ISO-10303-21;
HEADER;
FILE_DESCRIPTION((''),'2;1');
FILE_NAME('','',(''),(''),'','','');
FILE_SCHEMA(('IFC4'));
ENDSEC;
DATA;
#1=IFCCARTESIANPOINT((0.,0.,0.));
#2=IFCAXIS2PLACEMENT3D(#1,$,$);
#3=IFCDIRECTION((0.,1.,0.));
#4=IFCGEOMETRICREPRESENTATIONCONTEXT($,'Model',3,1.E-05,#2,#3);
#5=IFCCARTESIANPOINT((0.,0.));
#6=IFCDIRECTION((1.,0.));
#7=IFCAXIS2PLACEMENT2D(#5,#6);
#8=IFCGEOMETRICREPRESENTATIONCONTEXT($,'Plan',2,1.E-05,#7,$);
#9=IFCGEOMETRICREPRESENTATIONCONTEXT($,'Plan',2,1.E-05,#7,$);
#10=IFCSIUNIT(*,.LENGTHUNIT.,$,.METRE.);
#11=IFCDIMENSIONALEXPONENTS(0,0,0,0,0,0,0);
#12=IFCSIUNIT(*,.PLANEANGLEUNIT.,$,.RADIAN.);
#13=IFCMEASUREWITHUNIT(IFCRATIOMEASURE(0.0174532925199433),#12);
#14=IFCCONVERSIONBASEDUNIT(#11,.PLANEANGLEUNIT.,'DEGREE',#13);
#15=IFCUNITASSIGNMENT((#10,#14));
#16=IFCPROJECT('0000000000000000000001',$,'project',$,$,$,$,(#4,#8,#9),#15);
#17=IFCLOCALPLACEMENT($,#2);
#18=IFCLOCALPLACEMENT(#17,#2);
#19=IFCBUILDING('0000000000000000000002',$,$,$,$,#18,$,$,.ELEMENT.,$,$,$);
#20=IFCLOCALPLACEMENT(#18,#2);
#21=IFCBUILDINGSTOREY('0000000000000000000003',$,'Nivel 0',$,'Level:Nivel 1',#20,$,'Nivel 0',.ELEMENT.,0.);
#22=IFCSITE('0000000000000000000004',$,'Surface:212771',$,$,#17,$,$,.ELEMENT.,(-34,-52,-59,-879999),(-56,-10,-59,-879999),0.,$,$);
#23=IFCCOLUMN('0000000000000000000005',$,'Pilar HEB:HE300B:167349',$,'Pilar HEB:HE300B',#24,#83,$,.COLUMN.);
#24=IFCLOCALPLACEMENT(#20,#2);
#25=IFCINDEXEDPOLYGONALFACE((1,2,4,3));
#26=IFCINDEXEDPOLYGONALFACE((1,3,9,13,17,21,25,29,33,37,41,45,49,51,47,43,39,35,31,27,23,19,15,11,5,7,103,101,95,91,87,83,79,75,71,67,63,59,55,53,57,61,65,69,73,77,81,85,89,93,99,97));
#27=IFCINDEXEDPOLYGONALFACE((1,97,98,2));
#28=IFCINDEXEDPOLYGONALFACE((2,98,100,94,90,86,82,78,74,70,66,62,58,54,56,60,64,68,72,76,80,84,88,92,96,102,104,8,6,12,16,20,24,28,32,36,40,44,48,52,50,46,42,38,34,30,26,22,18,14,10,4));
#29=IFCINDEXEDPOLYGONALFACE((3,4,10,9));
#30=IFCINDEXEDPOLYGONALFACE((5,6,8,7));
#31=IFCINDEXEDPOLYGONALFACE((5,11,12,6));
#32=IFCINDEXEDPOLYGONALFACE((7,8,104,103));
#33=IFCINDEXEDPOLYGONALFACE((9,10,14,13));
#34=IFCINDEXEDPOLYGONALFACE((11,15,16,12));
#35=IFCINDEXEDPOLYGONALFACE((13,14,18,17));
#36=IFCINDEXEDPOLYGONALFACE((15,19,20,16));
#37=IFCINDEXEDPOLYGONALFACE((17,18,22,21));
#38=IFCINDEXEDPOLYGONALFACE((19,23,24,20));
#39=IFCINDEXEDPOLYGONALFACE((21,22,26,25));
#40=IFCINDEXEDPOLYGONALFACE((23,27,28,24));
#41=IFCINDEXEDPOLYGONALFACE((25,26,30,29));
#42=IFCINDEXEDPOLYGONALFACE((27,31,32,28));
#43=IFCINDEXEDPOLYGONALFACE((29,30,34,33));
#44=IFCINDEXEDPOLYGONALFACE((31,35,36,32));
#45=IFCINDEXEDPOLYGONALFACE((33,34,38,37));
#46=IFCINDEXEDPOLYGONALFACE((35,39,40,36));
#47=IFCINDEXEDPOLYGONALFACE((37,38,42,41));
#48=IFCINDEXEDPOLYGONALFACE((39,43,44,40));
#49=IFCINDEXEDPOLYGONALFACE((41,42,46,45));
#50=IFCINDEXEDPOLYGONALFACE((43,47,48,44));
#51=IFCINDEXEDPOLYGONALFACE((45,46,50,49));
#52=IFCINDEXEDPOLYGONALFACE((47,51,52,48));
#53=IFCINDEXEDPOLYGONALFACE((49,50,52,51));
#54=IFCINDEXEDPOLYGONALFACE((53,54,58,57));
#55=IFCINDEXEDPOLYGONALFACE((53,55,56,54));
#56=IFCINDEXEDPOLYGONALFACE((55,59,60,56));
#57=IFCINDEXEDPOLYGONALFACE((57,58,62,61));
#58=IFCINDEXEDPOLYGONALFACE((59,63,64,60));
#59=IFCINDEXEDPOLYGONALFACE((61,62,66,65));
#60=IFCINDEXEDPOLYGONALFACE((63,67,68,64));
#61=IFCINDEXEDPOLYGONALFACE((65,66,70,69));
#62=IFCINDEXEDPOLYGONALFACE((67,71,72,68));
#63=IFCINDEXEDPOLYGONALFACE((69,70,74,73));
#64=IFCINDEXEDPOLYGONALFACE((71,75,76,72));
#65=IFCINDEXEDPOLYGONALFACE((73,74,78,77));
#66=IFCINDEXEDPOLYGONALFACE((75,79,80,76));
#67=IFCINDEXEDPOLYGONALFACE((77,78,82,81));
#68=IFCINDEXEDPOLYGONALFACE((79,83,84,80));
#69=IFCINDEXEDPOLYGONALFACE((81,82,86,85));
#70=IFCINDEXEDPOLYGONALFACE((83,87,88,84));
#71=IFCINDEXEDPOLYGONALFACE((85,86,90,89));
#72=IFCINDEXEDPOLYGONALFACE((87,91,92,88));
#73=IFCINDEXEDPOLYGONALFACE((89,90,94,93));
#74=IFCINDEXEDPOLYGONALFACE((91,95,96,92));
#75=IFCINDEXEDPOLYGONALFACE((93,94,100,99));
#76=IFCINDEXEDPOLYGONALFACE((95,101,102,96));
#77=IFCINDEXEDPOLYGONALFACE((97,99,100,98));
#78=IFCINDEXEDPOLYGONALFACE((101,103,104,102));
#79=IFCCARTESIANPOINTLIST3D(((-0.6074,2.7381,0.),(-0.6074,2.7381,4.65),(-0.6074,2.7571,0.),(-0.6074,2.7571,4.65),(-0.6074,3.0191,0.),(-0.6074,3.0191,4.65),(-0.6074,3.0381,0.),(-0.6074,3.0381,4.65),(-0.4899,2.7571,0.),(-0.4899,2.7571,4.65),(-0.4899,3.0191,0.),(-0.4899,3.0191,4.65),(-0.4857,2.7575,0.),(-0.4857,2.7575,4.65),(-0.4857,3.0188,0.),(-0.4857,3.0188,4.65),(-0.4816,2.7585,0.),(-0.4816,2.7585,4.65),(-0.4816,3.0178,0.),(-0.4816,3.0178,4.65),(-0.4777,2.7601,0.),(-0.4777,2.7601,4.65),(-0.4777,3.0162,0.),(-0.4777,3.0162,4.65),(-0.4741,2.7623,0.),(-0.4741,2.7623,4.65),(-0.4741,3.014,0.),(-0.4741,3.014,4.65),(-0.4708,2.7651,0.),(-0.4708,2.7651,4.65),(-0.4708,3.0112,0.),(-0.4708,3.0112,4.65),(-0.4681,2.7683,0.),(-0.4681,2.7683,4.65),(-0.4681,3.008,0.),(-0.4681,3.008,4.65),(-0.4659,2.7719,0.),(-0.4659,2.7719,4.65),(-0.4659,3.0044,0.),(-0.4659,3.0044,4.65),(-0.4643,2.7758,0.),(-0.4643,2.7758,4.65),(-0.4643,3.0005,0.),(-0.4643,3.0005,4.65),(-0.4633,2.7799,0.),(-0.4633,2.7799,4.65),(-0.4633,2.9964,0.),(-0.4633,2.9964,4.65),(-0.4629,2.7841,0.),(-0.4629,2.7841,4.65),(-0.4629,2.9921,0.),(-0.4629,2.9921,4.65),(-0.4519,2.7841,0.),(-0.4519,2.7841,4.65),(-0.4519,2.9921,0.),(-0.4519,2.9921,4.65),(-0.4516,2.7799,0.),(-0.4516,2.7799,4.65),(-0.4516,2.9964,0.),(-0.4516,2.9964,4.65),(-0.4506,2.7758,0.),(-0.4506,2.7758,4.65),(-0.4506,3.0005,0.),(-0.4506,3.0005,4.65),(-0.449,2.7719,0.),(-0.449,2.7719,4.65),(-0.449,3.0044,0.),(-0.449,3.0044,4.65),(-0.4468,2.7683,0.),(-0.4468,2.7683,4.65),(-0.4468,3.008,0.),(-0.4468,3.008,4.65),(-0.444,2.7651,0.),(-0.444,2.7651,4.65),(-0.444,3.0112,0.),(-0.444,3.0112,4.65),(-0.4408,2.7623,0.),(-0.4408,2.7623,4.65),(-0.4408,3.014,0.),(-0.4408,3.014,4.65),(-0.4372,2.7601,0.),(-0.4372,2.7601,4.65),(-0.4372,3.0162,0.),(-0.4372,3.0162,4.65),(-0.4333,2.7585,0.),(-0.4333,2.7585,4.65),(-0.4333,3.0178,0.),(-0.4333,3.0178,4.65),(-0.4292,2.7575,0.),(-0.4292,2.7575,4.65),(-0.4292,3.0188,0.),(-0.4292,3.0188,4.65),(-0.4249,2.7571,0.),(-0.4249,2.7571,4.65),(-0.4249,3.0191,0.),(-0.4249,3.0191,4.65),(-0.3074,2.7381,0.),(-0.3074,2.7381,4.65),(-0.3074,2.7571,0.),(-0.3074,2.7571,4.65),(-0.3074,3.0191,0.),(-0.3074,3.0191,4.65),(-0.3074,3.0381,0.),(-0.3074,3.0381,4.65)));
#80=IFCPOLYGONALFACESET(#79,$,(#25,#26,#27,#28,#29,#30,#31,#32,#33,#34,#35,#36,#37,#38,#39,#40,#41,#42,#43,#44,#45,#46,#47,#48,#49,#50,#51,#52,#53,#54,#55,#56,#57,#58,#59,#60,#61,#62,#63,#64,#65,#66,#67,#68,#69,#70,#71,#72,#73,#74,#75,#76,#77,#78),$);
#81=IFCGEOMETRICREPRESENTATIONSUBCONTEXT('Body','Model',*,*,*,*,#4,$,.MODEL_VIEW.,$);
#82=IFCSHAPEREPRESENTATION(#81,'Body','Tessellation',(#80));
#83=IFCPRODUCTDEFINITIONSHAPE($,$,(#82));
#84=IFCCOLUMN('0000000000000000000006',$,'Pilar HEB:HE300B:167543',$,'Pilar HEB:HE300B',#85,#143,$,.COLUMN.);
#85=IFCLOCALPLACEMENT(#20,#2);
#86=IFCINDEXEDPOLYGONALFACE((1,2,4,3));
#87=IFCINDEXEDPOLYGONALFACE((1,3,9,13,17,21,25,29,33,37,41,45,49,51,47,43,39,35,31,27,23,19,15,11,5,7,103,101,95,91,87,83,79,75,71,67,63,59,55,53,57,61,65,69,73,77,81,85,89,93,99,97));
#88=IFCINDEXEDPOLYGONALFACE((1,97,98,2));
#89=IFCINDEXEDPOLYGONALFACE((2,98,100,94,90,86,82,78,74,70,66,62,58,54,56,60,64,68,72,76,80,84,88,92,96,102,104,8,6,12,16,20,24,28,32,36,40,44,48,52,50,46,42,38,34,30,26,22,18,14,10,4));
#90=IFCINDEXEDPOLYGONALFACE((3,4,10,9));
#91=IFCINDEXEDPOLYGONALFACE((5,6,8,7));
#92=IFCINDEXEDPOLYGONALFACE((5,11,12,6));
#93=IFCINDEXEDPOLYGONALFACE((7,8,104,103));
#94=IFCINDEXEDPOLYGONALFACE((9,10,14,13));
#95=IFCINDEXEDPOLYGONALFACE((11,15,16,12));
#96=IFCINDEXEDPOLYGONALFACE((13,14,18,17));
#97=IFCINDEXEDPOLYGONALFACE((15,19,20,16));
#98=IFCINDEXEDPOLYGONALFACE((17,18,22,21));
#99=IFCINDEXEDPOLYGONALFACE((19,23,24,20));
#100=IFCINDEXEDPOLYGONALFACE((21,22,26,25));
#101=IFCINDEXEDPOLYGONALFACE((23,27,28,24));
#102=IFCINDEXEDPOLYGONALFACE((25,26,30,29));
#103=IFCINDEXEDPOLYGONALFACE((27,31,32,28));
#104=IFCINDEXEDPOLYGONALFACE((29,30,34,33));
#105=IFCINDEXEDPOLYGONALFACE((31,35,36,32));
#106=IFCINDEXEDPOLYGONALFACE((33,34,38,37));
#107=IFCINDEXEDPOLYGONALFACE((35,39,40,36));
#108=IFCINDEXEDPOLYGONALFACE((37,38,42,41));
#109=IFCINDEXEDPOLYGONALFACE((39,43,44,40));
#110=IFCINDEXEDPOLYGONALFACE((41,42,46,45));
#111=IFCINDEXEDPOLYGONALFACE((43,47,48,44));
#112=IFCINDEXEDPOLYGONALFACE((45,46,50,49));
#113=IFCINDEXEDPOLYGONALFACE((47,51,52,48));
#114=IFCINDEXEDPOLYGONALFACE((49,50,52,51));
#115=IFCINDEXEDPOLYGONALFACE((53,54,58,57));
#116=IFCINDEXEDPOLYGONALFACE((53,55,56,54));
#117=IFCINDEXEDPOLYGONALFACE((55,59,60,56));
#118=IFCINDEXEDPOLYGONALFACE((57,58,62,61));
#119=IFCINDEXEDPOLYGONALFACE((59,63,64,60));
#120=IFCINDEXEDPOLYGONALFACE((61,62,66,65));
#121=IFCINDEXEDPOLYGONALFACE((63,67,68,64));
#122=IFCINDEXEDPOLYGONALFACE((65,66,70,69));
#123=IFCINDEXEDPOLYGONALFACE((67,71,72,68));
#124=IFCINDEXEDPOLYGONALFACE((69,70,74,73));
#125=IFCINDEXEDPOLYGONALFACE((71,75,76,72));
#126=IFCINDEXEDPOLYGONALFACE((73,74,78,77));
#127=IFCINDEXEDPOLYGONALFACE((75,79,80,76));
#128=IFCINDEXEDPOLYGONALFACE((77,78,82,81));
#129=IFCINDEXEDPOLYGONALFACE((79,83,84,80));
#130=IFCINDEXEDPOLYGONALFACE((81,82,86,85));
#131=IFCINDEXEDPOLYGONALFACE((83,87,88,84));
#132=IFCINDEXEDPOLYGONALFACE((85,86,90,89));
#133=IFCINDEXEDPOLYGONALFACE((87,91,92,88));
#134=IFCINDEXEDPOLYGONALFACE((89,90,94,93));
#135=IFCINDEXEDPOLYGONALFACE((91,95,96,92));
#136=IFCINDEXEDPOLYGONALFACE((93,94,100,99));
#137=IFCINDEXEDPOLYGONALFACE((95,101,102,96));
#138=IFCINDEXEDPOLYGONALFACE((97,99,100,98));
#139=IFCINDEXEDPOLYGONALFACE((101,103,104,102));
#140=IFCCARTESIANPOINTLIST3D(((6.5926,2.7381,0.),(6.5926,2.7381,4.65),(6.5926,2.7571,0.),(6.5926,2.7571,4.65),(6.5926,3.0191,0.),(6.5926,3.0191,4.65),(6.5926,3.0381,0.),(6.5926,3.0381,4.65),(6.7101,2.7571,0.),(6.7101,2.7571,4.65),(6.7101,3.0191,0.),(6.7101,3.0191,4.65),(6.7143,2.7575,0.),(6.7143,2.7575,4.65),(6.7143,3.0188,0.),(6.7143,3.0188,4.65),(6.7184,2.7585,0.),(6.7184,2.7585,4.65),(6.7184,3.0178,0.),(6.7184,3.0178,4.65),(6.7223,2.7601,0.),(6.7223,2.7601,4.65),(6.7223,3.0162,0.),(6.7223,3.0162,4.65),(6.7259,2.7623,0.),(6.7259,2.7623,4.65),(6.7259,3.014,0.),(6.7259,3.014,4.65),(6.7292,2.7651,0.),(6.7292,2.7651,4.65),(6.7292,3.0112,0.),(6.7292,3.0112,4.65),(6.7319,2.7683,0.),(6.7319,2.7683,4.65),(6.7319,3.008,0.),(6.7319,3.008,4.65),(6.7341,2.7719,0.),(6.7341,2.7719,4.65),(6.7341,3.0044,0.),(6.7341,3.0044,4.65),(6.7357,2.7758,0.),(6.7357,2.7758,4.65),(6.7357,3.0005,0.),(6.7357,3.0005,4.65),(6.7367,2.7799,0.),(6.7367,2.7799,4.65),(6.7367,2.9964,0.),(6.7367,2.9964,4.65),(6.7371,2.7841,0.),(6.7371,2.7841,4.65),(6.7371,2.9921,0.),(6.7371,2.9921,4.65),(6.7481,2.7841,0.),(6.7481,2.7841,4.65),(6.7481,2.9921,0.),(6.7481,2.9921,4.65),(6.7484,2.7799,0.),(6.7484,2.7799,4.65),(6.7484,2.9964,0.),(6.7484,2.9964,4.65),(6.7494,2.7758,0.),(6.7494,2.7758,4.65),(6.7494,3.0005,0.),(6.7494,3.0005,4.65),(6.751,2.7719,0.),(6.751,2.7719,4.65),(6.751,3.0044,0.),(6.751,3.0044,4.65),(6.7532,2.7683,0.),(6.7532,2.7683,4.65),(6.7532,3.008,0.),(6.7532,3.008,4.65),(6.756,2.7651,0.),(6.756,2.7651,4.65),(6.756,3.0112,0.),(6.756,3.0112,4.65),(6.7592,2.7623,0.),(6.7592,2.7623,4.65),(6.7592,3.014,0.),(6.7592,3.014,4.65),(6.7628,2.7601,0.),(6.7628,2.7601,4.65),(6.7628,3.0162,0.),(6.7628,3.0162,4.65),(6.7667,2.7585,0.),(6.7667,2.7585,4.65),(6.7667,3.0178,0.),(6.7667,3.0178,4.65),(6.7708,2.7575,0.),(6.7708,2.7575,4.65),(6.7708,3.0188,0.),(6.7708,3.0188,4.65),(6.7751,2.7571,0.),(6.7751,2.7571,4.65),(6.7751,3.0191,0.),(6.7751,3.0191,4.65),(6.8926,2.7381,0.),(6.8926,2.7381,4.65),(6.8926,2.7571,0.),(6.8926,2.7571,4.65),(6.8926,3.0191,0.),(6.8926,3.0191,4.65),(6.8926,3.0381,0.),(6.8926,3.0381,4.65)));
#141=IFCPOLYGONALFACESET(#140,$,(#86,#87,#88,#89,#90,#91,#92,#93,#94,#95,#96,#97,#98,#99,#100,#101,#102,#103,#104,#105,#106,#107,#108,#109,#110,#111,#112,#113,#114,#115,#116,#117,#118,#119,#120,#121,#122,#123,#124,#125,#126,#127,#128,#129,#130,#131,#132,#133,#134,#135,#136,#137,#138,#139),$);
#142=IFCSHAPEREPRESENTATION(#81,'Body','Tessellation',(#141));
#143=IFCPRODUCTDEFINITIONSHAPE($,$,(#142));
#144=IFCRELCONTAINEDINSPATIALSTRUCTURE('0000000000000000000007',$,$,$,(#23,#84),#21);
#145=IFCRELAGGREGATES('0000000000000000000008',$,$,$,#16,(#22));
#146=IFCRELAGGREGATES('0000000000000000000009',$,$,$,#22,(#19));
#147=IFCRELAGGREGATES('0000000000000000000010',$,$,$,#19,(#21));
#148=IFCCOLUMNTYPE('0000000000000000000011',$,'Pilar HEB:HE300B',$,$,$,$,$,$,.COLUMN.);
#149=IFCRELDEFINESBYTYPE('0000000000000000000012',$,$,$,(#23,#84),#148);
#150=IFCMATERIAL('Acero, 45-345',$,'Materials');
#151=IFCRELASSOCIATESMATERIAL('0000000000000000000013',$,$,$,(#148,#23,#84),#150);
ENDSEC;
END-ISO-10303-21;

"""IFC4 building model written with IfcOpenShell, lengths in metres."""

from ifc_helpers import new_model, entity, si_unit, converted_unit, direction, frame, origin, origin_2d_with_axis, place, context, subcontext, project, spatial, polyline, outline, extrude, source, transform, mapped, material, type_object, type_shapes, element, save


model = new_model("IFC4")

# Units and contexts
model_context = context("Model", 3, precision=1e-05, world=origin(), true_north=direction((0.0, 1.0, 0.0)))
plan_context_1 = context("Plan", 2, precision=1e-05, world=origin_2d_with_axis())
plan_context_2 = context("Plan", 2, precision=1e-05, world=origin_2d_with_axis())
body_context = subcontext(model_context, "Body", "Model", "MODEL_VIEW")
ifc_project = project(units=[si_unit("LENGTHUNIT", "METRE"), converted_unit("PLANEANGLEUNIT", "DEGREE", entity("IfcRatioMeasure", 0.0174532925199433), si_unit("PLANEANGLEUNIT", "RADIAN"), dimensions=[0, 0, 0, 0, 0, 0, 0])], contexts=[model_context, plan_context_1, plan_context_2])

# Site, building, storey
site_placement = place(None, origin())
site = spatial("IfcSite", under=ifc_project, at=site_placement, Name="Surface:212771", CompositionType="ELEMENT", RefLatitude=(-34, -52, -59, -879999), RefLongitude=(-56, -10, -59, -879999), RefElevation=0.0)
building_placement = place(site_placement, origin())
building = spatial("IfcBuilding", under=site, at=building_placement, CompositionType="ELEMENT")
storey_placement = place(building_placement, origin())
storey = spatial("IfcBuildingStorey", under=building, at=storey_placement, Name="Nivel 0", ObjectType="Level:Nivel 1", LongName="Nivel 0", CompositionType="ELEMENT", Elevation=0.0)

# Columns
ifc_material_1 = material(Name="Acero, 45-345", Category="Materials")
column_type_1 = type_object("IfcColumnType", Name="Pilar HEB:HE300B", PredefinedType="COLUMN", material=ifc_material_1)
shared_shape_1 = source(origin(), body_context, "Body", "SweptSolid", [
    extrude(outline(polyline([(0.1041, 0.0), (0.1084, -0.0001), (0.1125, -0.0009), (0.1165, -0.0023), (0.1203, -0.0043), (0.1236, -0.0069), (0.1265, -0.01), (0.1289, -0.0135), (0.1308, -0.0173), (0.132, -0.0213), (0.1325, -0.0255), (0.1387, -0.1429), (0.1577, -0.1419), (0.1419, 0.1577), (0.1229, 0.1567), (0.1291, 0.0394), (0.129, 0.0351), (0.1282, 0.031), (0.1268, 0.027), (0.1248, 0.0233), (0.1222, 0.0199), (0.1191, 0.017), (0.1156, 0.0146), (0.1118, 0.0127), (0.1078, 0.0115), (0.1036, 0.011), (-0.1041, 0.0), (-0.1084, 0.0001), (-0.1125, 0.0009), (-0.1165, 0.0023), (-0.1203, 0.0043), (-0.1236, 0.0069), (-0.1265, 0.01), (-0.1289, 0.0135), (-0.1308, 0.0173), (-0.132, 0.0213), (-0.1325, 0.0255), (-0.1387, 0.1429), (-0.1577, 0.1419), (-0.1419, -0.1577), (-0.1229, -0.1567), (-0.1291, -0.0394), (-0.129, -0.0351), (-0.1282, -0.031), (-0.1268, -0.027), (-0.1248, -0.0233), (-0.1222, -0.0199), (-0.1191, -0.017), (-0.1156, -0.0146), (-0.1118, -0.0127), (-0.1078, -0.0115), (-0.1036, -0.011), (0.1041, 0.0)])), frame((0.0, 0.0, 0.0), z_axis=(0.0, 0.0, -1.0), x_axis=(0.052811, -0.998605, 0.0)), (0.0, 0.0, -1.0), 4.65),
])
type_shapes(column_type_1, [shared_shape_1])
for number, where, z_axis, x_axis, name in (
    (1, (-0.4574, 2.8881, 0.0), (0.0, 0.0, 2.132179), (1.0, 0.0, 0.0), "Pilar HEB:HE300B:167349"),
    (2, (6.7426, 2.8881, 0.0), (0.0, 0.0, 2.132179), (1.0, 0.0, 0.0), "Pilar HEB:HE300B:167543"),
):
    element("IfcColumn", number, at=place(storey_placement, frame(where, z_axis=z_axis, x_axis=x_axis)), inside=storey, type_object=column_type_1, material=ifc_material_1, Name=name, ObjectType="Pilar HEB:HE300B", PredefinedType="COLUMN", context=body_context, shape_type="MappedRepresentation", body=[
        mapped(shared_shape_1, transform((0.0, 0.0, 0.0), scale=1.0)),
    ])

save(model, "model.ifc")
